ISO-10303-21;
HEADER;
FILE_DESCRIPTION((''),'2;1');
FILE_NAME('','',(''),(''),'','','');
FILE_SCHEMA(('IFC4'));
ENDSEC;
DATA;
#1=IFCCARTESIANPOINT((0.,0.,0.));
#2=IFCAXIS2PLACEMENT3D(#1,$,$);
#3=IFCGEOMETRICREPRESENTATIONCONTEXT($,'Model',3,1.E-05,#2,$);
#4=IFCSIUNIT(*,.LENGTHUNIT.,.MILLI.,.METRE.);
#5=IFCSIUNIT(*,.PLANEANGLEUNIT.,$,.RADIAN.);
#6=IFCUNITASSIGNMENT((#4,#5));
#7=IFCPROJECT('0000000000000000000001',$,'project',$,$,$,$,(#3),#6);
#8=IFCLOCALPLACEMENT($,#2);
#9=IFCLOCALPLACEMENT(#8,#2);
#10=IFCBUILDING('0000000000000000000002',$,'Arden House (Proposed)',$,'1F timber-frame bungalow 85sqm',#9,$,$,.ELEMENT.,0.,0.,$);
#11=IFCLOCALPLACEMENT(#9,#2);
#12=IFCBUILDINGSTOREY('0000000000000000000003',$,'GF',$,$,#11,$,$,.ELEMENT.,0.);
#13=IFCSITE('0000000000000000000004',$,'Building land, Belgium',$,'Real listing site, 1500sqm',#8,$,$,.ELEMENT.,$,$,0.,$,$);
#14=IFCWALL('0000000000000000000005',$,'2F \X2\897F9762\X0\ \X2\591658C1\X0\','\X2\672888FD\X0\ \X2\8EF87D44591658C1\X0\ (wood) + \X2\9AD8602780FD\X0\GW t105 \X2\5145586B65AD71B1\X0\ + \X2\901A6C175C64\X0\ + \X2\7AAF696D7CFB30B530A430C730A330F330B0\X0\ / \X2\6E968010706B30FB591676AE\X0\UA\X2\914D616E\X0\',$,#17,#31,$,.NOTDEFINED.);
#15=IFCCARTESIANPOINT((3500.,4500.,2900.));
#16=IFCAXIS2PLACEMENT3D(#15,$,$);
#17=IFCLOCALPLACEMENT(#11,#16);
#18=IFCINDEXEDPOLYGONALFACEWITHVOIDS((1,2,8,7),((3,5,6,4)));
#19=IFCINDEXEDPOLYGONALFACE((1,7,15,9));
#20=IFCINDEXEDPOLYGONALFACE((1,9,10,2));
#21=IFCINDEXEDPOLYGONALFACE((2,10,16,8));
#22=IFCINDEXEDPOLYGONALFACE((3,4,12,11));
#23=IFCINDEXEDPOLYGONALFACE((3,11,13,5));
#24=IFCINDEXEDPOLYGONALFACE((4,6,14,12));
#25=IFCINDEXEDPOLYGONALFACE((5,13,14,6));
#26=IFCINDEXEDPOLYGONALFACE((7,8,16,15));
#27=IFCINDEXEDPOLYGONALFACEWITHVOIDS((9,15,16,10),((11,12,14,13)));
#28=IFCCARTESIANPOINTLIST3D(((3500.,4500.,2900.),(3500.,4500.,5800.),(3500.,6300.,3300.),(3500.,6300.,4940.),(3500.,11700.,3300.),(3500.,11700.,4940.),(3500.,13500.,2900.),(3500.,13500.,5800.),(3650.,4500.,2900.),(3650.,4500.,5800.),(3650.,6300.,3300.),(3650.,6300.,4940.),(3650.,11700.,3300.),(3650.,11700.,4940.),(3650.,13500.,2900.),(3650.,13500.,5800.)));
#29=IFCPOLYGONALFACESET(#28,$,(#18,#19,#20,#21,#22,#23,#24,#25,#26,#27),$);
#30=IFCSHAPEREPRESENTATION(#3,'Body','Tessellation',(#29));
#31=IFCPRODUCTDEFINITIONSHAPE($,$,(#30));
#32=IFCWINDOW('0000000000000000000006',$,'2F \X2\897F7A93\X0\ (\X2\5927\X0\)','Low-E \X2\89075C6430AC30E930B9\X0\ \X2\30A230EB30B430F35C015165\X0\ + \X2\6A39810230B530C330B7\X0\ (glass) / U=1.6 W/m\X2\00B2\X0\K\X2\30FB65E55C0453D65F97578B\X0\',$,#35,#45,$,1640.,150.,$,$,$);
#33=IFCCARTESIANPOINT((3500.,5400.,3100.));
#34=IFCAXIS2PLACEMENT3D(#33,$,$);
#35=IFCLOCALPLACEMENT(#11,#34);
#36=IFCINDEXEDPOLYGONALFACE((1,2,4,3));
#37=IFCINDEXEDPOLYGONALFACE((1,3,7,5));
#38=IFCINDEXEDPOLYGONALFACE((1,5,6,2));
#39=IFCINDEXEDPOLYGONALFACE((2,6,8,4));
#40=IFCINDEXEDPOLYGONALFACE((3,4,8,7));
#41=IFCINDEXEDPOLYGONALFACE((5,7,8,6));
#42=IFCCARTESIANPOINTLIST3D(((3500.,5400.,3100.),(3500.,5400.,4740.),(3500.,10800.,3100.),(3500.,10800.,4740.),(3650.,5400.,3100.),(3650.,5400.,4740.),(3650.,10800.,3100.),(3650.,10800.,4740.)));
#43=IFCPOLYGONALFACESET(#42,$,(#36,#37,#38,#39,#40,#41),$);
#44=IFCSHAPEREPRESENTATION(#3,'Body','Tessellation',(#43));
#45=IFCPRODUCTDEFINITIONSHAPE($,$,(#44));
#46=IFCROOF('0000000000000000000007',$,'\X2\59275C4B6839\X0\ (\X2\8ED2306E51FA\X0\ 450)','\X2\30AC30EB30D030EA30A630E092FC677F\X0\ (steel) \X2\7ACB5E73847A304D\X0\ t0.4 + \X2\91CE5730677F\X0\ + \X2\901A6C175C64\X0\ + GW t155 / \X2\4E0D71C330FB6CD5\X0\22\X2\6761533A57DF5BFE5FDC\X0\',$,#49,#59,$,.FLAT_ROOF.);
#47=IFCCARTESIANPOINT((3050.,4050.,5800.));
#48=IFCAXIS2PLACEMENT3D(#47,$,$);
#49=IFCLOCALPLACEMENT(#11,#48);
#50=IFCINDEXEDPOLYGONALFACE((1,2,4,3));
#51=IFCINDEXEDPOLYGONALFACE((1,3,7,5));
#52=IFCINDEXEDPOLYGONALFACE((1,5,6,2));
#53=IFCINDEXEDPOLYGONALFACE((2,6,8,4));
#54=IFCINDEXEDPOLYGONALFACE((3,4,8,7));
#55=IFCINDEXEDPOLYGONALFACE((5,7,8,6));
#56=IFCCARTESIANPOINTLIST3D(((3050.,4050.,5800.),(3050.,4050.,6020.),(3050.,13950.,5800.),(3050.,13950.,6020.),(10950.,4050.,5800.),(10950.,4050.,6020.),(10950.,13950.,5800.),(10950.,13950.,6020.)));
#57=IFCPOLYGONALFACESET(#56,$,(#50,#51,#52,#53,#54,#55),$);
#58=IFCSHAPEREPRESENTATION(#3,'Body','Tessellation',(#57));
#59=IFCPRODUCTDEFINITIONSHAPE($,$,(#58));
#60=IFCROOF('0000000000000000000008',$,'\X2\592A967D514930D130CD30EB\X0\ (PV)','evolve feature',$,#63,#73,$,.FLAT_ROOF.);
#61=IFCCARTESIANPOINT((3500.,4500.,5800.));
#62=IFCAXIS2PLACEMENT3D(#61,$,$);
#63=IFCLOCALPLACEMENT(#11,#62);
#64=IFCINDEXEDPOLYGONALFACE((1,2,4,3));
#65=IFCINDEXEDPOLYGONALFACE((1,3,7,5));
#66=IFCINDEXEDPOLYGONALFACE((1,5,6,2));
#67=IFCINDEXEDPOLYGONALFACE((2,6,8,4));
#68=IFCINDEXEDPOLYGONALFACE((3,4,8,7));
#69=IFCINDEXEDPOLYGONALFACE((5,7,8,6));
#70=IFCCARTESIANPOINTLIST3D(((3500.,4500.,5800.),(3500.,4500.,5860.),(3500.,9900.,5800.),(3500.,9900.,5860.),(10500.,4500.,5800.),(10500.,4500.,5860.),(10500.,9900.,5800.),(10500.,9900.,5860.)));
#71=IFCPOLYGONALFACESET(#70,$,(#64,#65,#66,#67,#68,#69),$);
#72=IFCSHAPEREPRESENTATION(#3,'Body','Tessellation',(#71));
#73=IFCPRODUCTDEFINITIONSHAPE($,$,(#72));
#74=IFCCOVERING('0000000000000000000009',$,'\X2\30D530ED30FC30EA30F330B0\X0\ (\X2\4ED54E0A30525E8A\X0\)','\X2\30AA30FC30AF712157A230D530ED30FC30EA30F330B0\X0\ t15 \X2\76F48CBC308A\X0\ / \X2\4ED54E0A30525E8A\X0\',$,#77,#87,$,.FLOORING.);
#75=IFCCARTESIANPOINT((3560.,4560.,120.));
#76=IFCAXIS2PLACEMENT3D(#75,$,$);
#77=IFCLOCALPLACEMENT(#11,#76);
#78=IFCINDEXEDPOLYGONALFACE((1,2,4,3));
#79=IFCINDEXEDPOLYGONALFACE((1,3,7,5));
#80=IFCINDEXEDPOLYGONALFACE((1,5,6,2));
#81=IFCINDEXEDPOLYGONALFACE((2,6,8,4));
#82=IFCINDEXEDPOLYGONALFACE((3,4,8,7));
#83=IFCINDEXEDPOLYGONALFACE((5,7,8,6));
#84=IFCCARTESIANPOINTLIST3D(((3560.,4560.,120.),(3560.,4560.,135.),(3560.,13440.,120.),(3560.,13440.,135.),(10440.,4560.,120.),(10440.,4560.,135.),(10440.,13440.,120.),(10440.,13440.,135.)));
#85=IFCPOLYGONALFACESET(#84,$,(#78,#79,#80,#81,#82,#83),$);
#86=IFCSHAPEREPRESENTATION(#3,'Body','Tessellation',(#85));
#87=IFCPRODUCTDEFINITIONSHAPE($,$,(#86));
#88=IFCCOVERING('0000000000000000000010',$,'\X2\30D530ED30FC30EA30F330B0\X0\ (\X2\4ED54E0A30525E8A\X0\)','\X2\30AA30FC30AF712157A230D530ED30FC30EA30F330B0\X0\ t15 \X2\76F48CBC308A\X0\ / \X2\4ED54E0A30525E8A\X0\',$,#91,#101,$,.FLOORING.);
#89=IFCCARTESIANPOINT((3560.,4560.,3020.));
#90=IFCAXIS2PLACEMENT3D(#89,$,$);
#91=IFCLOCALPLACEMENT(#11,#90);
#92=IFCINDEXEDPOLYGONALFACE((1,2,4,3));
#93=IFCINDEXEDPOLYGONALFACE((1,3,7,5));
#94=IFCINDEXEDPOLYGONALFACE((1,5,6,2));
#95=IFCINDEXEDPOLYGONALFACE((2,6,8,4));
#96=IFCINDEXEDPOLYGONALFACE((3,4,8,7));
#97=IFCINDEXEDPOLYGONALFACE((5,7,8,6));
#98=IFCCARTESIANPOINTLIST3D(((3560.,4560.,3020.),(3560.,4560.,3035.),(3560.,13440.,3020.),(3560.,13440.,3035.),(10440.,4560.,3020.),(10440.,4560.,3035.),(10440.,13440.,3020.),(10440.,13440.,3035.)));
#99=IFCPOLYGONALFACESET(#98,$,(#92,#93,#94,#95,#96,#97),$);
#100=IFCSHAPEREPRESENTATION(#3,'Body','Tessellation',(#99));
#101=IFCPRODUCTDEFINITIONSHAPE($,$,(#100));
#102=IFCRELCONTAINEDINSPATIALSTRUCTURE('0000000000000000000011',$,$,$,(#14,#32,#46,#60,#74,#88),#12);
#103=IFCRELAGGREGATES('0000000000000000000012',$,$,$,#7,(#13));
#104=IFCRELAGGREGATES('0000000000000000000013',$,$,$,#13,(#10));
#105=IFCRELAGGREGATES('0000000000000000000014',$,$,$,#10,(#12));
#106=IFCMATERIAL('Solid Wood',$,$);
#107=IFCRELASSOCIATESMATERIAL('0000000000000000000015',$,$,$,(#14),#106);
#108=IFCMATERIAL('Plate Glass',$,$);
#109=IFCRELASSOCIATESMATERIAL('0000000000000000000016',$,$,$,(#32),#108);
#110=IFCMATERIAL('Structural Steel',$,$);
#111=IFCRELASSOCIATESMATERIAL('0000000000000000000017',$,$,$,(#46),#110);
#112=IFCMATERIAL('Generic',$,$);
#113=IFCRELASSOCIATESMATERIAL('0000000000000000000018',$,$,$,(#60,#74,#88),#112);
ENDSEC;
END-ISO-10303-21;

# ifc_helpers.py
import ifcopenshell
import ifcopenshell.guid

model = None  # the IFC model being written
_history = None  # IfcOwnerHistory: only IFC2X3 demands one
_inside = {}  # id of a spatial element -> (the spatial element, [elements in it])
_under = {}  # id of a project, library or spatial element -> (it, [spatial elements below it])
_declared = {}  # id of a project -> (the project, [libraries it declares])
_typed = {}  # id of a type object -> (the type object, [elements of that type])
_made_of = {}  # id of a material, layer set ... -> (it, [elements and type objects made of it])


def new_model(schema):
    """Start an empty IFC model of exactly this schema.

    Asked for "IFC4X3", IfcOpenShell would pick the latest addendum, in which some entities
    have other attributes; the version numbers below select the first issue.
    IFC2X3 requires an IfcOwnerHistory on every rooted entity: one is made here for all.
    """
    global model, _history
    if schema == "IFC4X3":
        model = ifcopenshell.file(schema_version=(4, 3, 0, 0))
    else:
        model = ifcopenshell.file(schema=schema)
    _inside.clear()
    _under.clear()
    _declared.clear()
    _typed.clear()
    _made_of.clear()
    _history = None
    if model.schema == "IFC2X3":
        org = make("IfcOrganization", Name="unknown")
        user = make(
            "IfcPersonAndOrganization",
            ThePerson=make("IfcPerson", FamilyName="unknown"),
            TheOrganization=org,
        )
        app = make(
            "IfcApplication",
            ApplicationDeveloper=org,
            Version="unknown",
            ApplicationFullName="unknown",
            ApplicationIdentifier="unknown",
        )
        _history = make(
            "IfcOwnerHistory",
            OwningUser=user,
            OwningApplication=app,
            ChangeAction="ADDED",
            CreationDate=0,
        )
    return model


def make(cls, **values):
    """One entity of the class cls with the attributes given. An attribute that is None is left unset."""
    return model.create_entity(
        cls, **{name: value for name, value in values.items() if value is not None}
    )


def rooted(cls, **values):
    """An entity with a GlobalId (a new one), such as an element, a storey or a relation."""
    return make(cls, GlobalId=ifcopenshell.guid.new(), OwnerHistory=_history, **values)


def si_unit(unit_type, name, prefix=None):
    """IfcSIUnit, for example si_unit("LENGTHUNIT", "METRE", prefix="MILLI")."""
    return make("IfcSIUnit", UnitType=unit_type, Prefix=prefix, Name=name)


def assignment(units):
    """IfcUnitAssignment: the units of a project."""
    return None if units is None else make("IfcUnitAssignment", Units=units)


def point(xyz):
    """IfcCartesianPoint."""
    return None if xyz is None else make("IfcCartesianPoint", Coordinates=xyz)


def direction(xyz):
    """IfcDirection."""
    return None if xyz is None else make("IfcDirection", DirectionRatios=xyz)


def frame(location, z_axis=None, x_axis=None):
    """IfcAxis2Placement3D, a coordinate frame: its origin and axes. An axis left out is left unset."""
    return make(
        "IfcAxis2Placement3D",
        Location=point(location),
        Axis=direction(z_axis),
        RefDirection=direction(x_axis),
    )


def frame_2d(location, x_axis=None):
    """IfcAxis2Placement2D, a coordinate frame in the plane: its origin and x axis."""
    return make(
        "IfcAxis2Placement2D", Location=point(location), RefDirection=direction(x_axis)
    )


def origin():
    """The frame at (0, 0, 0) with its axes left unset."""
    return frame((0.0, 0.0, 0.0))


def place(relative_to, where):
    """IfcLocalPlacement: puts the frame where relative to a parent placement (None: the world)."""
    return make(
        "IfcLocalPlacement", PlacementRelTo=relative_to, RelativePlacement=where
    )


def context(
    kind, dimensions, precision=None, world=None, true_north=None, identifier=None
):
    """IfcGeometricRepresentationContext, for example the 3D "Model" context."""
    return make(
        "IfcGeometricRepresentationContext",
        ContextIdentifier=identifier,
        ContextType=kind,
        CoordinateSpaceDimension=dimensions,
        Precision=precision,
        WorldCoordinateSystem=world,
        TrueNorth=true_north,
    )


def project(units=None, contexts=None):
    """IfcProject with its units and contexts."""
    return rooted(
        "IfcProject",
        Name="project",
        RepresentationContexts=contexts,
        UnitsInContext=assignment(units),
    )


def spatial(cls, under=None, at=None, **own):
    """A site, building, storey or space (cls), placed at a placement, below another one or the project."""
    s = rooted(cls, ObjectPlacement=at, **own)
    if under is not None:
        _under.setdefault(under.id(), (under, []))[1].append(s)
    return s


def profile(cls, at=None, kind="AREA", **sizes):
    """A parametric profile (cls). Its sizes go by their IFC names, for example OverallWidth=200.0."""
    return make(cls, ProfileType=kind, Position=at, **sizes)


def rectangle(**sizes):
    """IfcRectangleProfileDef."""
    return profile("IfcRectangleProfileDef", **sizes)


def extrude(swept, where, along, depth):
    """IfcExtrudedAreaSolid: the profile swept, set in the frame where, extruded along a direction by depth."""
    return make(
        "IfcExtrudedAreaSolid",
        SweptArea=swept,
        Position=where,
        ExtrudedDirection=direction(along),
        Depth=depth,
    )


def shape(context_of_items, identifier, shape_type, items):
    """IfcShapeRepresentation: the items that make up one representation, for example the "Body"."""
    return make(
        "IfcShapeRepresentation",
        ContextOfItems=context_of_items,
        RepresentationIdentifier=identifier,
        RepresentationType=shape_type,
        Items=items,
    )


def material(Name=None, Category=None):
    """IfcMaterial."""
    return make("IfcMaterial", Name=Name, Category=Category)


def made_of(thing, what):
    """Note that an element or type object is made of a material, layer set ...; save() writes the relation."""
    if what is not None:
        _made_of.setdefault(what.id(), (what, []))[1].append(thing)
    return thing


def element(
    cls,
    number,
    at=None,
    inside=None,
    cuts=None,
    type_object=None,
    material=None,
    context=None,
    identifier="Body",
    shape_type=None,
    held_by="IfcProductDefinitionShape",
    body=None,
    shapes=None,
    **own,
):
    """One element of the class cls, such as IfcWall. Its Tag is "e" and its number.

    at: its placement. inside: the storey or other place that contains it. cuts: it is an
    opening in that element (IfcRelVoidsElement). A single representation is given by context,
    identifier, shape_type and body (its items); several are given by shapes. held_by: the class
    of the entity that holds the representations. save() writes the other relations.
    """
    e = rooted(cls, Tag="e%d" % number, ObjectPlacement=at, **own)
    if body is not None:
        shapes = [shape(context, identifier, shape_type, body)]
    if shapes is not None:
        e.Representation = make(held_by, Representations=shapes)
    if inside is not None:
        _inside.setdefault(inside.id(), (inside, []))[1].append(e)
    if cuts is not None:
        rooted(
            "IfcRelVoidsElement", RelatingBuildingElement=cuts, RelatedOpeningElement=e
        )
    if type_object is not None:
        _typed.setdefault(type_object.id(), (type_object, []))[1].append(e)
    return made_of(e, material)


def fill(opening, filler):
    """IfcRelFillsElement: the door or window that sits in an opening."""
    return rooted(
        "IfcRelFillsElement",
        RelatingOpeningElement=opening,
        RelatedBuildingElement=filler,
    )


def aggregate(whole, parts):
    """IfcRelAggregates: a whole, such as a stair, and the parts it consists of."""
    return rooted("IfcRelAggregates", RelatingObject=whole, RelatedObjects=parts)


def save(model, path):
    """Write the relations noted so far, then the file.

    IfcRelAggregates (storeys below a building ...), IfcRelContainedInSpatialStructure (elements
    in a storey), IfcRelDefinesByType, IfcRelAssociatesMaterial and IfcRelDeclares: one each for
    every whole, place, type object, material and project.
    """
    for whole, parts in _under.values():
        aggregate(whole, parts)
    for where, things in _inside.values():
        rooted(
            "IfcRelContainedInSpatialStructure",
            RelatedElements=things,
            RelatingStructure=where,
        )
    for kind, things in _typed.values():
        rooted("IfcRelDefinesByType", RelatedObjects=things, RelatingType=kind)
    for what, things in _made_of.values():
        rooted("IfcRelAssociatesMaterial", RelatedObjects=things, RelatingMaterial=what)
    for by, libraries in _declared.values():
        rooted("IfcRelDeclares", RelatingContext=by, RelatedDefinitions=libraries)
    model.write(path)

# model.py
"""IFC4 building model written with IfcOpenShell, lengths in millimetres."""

from ifc_helpers import new_model, si_unit, frame, frame_2d, origin, place, context, project, spatial, rectangle, extrude, material, element, fill, save


model = new_model("IFC4")

# Units and contexts
model_context = context("Model", 3, precision=1e-05, world=origin())
ifc_project = project(units=[si_unit("LENGTHUNIT", "METRE", prefix="MILLI"), si_unit("PLANEANGLEUNIT", "RADIAN")], contexts=[model_context])

# Site, building, storey
site_placement = place(None, origin())
site = spatial("IfcSite", under=ifc_project, at=site_placement, Name="Building land, Belgium", ObjectType="Real listing site, 1500sqm", CompositionType="ELEMENT", RefElevation=0.0)
building_placement = place(site_placement, origin())
building = spatial("IfcBuilding", under=site, at=building_placement, Name="Arden House (Proposed)", ObjectType="1F timber-frame bungalow 85sqm", CompositionType="ELEMENT", ElevationOfRefHeight=0.0, ElevationOfTerrain=0.0)
storey_placement = place(building_placement, origin())
storey = spatial("IfcBuildingStorey", under=building, at=storey_placement, Name="GF", CompositionType="ELEMENT", Elevation=0.0)

# Shared definitions
ifc_material_1 = material(Name="Solid Wood")
ifc_material_2 = material(Name="Generic")

# Shared definitions
ifc_material_3 = material(Name="Plate Glass")

# Wall, opening, window
wall_1_placement = place(storey_placement, frame((3500.0, 4500.0, 2900.0)))
wall_1 = element("IfcWall", 1, at=wall_1_placement, inside=storey, material=ifc_material_1, Name="2F 西面 外壁", Description="木製 軸組外壁 (wood) + 高性能GW t105 充填断熱 + 通気層 + 窯業系サイディング / 準耐火・外皮UA配慮", PredefinedType="NOTDEFINED", context=model_context, shape_type="SweptSolid", body=[
    extrude(rectangle(XDim=150.0, YDim=9000.0, at=frame_2d((75.0, 4500.0))), frame((3500.0, 4500.0, 2900.0)), (0.0, 0.0, 1.0), 2900.0),
])
opening_1_placement = place(storey_placement, frame((3500.0, 5400.0, 3100.0)))
opening_1 = element("IfcOpeningElement", 2, at=opening_1_placement, cuts=wall_1, PredefinedType="NOTDEFINED", context=model_context, shape_type="SweptSolid", body=[
    extrude(rectangle(XDim=150.0, YDim=5400.0, at=frame_2d((75.0, 2700.0))), frame((3500.0, 5400.0, 3100.0)), (0.0, 0.0, 1.0), 1640.0),
])
window_1_placement = place(storey_placement, frame((3500.0, 5400.0, 3100.0)))
window_1 = element("IfcWindow", 3, at=window_1_placement, inside=storey, material=ifc_material_3, Name="2F 西窓 (大)", Description="Low-E 複層ガラス アルゴン封入 + 樹脂サッシ (glass) / U=1.6 W/m²K・日射取得型", OverallHeight=1640.0, OverallWidth=150.0, context=model_context, shape_type="SweptSolid", body=[
    extrude(rectangle(XDim=150.0, YDim=5400.0, at=frame_2d((75.0, 2700.0))), frame((3500.0, 5400.0, 3100.0)), (0.0, 0.0, 1.0), 1640.0),
])
fill(opening_1, window_1)

# Roofs
ifc_material_4 = material(Name="Structural Steel")
roof_1_placement = place(storey_placement, frame((3050.0, 4050.0, 5800.0)))
element("IfcRoof", 4, at=roof_1_placement, inside=storey, material=ifc_material_4, Name="大屋根 (軒の出 450)", Description="ガルバリウム鋼板 (steel) 立平葺き t0.4 + 野地板 + 通気層 + GW t155 / 不燃・法22条区域対応", PredefinedType="FLAT_ROOF", context=model_context, shape_type="SweptSolid", body=[
    extrude(rectangle(XDim=7900.0, YDim=9900.0, at=frame_2d((3950.0, 4950.0))), frame((3050.0, 4050.0, 5800.0)), (0.0, 0.0, 1.0), 220.0),
])
roof_2_placement = place(storey_placement, frame((3500.0, 4500.0, 5800.0)))
element("IfcRoof", 5, at=roof_2_placement, inside=storey, material=ifc_material_2, Name="太陽光パネル (PV)", Description="evolve feature", PredefinedType="FLAT_ROOF", context=model_context, shape_type="SweptSolid", body=[
    extrude(rectangle(XDim=7000.0, YDim=5400.0, at=frame_2d((3500.0, 2700.0))), frame((3500.0, 4500.0, 5800.0)), (0.0, 0.0, 1.0), 60.0),
])

# Coverings
covering_1_placement = place(storey_placement, frame((3560.0, 4560.0, 120.0)))
element("IfcCovering", 6, at=covering_1_placement, inside=storey, material=ifc_material_2, Name="フローリング (仕上げ床)", Description="オーク無垢フローリング t15 直貼り / 仕上げ床", PredefinedType="FLOORING", context=model_context, shape_type="SweptSolid", body=[
    extrude(rectangle(XDim=6880.0, YDim=8880.0, at=frame_2d((3440.0, 4440.0))), frame((3560.0, 4560.0, 120.0)), (0.0, 0.0, 1.0), 15.0),
])
covering_2_placement = place(storey_placement, frame((3560.0, 4560.0, 3020.0)))
element("IfcCovering", 7, at=covering_2_placement, inside=storey, material=ifc_material_2, Name="フローリング (仕上げ床)", Description="オーク無垢フローリング t15 直貼り / 仕上げ床", PredefinedType="FLOORING", context=model_context, shape_type="SweptSolid", body=[
    extrude(rectangle(XDim=6880.0, YDim=8880.0, at=frame_2d((3440.0, 4440.0))), frame((3560.0, 4560.0, 3020.0)), (0.0, 0.0, 1.0), 15.0),
])

save(model, "model.ifc")
